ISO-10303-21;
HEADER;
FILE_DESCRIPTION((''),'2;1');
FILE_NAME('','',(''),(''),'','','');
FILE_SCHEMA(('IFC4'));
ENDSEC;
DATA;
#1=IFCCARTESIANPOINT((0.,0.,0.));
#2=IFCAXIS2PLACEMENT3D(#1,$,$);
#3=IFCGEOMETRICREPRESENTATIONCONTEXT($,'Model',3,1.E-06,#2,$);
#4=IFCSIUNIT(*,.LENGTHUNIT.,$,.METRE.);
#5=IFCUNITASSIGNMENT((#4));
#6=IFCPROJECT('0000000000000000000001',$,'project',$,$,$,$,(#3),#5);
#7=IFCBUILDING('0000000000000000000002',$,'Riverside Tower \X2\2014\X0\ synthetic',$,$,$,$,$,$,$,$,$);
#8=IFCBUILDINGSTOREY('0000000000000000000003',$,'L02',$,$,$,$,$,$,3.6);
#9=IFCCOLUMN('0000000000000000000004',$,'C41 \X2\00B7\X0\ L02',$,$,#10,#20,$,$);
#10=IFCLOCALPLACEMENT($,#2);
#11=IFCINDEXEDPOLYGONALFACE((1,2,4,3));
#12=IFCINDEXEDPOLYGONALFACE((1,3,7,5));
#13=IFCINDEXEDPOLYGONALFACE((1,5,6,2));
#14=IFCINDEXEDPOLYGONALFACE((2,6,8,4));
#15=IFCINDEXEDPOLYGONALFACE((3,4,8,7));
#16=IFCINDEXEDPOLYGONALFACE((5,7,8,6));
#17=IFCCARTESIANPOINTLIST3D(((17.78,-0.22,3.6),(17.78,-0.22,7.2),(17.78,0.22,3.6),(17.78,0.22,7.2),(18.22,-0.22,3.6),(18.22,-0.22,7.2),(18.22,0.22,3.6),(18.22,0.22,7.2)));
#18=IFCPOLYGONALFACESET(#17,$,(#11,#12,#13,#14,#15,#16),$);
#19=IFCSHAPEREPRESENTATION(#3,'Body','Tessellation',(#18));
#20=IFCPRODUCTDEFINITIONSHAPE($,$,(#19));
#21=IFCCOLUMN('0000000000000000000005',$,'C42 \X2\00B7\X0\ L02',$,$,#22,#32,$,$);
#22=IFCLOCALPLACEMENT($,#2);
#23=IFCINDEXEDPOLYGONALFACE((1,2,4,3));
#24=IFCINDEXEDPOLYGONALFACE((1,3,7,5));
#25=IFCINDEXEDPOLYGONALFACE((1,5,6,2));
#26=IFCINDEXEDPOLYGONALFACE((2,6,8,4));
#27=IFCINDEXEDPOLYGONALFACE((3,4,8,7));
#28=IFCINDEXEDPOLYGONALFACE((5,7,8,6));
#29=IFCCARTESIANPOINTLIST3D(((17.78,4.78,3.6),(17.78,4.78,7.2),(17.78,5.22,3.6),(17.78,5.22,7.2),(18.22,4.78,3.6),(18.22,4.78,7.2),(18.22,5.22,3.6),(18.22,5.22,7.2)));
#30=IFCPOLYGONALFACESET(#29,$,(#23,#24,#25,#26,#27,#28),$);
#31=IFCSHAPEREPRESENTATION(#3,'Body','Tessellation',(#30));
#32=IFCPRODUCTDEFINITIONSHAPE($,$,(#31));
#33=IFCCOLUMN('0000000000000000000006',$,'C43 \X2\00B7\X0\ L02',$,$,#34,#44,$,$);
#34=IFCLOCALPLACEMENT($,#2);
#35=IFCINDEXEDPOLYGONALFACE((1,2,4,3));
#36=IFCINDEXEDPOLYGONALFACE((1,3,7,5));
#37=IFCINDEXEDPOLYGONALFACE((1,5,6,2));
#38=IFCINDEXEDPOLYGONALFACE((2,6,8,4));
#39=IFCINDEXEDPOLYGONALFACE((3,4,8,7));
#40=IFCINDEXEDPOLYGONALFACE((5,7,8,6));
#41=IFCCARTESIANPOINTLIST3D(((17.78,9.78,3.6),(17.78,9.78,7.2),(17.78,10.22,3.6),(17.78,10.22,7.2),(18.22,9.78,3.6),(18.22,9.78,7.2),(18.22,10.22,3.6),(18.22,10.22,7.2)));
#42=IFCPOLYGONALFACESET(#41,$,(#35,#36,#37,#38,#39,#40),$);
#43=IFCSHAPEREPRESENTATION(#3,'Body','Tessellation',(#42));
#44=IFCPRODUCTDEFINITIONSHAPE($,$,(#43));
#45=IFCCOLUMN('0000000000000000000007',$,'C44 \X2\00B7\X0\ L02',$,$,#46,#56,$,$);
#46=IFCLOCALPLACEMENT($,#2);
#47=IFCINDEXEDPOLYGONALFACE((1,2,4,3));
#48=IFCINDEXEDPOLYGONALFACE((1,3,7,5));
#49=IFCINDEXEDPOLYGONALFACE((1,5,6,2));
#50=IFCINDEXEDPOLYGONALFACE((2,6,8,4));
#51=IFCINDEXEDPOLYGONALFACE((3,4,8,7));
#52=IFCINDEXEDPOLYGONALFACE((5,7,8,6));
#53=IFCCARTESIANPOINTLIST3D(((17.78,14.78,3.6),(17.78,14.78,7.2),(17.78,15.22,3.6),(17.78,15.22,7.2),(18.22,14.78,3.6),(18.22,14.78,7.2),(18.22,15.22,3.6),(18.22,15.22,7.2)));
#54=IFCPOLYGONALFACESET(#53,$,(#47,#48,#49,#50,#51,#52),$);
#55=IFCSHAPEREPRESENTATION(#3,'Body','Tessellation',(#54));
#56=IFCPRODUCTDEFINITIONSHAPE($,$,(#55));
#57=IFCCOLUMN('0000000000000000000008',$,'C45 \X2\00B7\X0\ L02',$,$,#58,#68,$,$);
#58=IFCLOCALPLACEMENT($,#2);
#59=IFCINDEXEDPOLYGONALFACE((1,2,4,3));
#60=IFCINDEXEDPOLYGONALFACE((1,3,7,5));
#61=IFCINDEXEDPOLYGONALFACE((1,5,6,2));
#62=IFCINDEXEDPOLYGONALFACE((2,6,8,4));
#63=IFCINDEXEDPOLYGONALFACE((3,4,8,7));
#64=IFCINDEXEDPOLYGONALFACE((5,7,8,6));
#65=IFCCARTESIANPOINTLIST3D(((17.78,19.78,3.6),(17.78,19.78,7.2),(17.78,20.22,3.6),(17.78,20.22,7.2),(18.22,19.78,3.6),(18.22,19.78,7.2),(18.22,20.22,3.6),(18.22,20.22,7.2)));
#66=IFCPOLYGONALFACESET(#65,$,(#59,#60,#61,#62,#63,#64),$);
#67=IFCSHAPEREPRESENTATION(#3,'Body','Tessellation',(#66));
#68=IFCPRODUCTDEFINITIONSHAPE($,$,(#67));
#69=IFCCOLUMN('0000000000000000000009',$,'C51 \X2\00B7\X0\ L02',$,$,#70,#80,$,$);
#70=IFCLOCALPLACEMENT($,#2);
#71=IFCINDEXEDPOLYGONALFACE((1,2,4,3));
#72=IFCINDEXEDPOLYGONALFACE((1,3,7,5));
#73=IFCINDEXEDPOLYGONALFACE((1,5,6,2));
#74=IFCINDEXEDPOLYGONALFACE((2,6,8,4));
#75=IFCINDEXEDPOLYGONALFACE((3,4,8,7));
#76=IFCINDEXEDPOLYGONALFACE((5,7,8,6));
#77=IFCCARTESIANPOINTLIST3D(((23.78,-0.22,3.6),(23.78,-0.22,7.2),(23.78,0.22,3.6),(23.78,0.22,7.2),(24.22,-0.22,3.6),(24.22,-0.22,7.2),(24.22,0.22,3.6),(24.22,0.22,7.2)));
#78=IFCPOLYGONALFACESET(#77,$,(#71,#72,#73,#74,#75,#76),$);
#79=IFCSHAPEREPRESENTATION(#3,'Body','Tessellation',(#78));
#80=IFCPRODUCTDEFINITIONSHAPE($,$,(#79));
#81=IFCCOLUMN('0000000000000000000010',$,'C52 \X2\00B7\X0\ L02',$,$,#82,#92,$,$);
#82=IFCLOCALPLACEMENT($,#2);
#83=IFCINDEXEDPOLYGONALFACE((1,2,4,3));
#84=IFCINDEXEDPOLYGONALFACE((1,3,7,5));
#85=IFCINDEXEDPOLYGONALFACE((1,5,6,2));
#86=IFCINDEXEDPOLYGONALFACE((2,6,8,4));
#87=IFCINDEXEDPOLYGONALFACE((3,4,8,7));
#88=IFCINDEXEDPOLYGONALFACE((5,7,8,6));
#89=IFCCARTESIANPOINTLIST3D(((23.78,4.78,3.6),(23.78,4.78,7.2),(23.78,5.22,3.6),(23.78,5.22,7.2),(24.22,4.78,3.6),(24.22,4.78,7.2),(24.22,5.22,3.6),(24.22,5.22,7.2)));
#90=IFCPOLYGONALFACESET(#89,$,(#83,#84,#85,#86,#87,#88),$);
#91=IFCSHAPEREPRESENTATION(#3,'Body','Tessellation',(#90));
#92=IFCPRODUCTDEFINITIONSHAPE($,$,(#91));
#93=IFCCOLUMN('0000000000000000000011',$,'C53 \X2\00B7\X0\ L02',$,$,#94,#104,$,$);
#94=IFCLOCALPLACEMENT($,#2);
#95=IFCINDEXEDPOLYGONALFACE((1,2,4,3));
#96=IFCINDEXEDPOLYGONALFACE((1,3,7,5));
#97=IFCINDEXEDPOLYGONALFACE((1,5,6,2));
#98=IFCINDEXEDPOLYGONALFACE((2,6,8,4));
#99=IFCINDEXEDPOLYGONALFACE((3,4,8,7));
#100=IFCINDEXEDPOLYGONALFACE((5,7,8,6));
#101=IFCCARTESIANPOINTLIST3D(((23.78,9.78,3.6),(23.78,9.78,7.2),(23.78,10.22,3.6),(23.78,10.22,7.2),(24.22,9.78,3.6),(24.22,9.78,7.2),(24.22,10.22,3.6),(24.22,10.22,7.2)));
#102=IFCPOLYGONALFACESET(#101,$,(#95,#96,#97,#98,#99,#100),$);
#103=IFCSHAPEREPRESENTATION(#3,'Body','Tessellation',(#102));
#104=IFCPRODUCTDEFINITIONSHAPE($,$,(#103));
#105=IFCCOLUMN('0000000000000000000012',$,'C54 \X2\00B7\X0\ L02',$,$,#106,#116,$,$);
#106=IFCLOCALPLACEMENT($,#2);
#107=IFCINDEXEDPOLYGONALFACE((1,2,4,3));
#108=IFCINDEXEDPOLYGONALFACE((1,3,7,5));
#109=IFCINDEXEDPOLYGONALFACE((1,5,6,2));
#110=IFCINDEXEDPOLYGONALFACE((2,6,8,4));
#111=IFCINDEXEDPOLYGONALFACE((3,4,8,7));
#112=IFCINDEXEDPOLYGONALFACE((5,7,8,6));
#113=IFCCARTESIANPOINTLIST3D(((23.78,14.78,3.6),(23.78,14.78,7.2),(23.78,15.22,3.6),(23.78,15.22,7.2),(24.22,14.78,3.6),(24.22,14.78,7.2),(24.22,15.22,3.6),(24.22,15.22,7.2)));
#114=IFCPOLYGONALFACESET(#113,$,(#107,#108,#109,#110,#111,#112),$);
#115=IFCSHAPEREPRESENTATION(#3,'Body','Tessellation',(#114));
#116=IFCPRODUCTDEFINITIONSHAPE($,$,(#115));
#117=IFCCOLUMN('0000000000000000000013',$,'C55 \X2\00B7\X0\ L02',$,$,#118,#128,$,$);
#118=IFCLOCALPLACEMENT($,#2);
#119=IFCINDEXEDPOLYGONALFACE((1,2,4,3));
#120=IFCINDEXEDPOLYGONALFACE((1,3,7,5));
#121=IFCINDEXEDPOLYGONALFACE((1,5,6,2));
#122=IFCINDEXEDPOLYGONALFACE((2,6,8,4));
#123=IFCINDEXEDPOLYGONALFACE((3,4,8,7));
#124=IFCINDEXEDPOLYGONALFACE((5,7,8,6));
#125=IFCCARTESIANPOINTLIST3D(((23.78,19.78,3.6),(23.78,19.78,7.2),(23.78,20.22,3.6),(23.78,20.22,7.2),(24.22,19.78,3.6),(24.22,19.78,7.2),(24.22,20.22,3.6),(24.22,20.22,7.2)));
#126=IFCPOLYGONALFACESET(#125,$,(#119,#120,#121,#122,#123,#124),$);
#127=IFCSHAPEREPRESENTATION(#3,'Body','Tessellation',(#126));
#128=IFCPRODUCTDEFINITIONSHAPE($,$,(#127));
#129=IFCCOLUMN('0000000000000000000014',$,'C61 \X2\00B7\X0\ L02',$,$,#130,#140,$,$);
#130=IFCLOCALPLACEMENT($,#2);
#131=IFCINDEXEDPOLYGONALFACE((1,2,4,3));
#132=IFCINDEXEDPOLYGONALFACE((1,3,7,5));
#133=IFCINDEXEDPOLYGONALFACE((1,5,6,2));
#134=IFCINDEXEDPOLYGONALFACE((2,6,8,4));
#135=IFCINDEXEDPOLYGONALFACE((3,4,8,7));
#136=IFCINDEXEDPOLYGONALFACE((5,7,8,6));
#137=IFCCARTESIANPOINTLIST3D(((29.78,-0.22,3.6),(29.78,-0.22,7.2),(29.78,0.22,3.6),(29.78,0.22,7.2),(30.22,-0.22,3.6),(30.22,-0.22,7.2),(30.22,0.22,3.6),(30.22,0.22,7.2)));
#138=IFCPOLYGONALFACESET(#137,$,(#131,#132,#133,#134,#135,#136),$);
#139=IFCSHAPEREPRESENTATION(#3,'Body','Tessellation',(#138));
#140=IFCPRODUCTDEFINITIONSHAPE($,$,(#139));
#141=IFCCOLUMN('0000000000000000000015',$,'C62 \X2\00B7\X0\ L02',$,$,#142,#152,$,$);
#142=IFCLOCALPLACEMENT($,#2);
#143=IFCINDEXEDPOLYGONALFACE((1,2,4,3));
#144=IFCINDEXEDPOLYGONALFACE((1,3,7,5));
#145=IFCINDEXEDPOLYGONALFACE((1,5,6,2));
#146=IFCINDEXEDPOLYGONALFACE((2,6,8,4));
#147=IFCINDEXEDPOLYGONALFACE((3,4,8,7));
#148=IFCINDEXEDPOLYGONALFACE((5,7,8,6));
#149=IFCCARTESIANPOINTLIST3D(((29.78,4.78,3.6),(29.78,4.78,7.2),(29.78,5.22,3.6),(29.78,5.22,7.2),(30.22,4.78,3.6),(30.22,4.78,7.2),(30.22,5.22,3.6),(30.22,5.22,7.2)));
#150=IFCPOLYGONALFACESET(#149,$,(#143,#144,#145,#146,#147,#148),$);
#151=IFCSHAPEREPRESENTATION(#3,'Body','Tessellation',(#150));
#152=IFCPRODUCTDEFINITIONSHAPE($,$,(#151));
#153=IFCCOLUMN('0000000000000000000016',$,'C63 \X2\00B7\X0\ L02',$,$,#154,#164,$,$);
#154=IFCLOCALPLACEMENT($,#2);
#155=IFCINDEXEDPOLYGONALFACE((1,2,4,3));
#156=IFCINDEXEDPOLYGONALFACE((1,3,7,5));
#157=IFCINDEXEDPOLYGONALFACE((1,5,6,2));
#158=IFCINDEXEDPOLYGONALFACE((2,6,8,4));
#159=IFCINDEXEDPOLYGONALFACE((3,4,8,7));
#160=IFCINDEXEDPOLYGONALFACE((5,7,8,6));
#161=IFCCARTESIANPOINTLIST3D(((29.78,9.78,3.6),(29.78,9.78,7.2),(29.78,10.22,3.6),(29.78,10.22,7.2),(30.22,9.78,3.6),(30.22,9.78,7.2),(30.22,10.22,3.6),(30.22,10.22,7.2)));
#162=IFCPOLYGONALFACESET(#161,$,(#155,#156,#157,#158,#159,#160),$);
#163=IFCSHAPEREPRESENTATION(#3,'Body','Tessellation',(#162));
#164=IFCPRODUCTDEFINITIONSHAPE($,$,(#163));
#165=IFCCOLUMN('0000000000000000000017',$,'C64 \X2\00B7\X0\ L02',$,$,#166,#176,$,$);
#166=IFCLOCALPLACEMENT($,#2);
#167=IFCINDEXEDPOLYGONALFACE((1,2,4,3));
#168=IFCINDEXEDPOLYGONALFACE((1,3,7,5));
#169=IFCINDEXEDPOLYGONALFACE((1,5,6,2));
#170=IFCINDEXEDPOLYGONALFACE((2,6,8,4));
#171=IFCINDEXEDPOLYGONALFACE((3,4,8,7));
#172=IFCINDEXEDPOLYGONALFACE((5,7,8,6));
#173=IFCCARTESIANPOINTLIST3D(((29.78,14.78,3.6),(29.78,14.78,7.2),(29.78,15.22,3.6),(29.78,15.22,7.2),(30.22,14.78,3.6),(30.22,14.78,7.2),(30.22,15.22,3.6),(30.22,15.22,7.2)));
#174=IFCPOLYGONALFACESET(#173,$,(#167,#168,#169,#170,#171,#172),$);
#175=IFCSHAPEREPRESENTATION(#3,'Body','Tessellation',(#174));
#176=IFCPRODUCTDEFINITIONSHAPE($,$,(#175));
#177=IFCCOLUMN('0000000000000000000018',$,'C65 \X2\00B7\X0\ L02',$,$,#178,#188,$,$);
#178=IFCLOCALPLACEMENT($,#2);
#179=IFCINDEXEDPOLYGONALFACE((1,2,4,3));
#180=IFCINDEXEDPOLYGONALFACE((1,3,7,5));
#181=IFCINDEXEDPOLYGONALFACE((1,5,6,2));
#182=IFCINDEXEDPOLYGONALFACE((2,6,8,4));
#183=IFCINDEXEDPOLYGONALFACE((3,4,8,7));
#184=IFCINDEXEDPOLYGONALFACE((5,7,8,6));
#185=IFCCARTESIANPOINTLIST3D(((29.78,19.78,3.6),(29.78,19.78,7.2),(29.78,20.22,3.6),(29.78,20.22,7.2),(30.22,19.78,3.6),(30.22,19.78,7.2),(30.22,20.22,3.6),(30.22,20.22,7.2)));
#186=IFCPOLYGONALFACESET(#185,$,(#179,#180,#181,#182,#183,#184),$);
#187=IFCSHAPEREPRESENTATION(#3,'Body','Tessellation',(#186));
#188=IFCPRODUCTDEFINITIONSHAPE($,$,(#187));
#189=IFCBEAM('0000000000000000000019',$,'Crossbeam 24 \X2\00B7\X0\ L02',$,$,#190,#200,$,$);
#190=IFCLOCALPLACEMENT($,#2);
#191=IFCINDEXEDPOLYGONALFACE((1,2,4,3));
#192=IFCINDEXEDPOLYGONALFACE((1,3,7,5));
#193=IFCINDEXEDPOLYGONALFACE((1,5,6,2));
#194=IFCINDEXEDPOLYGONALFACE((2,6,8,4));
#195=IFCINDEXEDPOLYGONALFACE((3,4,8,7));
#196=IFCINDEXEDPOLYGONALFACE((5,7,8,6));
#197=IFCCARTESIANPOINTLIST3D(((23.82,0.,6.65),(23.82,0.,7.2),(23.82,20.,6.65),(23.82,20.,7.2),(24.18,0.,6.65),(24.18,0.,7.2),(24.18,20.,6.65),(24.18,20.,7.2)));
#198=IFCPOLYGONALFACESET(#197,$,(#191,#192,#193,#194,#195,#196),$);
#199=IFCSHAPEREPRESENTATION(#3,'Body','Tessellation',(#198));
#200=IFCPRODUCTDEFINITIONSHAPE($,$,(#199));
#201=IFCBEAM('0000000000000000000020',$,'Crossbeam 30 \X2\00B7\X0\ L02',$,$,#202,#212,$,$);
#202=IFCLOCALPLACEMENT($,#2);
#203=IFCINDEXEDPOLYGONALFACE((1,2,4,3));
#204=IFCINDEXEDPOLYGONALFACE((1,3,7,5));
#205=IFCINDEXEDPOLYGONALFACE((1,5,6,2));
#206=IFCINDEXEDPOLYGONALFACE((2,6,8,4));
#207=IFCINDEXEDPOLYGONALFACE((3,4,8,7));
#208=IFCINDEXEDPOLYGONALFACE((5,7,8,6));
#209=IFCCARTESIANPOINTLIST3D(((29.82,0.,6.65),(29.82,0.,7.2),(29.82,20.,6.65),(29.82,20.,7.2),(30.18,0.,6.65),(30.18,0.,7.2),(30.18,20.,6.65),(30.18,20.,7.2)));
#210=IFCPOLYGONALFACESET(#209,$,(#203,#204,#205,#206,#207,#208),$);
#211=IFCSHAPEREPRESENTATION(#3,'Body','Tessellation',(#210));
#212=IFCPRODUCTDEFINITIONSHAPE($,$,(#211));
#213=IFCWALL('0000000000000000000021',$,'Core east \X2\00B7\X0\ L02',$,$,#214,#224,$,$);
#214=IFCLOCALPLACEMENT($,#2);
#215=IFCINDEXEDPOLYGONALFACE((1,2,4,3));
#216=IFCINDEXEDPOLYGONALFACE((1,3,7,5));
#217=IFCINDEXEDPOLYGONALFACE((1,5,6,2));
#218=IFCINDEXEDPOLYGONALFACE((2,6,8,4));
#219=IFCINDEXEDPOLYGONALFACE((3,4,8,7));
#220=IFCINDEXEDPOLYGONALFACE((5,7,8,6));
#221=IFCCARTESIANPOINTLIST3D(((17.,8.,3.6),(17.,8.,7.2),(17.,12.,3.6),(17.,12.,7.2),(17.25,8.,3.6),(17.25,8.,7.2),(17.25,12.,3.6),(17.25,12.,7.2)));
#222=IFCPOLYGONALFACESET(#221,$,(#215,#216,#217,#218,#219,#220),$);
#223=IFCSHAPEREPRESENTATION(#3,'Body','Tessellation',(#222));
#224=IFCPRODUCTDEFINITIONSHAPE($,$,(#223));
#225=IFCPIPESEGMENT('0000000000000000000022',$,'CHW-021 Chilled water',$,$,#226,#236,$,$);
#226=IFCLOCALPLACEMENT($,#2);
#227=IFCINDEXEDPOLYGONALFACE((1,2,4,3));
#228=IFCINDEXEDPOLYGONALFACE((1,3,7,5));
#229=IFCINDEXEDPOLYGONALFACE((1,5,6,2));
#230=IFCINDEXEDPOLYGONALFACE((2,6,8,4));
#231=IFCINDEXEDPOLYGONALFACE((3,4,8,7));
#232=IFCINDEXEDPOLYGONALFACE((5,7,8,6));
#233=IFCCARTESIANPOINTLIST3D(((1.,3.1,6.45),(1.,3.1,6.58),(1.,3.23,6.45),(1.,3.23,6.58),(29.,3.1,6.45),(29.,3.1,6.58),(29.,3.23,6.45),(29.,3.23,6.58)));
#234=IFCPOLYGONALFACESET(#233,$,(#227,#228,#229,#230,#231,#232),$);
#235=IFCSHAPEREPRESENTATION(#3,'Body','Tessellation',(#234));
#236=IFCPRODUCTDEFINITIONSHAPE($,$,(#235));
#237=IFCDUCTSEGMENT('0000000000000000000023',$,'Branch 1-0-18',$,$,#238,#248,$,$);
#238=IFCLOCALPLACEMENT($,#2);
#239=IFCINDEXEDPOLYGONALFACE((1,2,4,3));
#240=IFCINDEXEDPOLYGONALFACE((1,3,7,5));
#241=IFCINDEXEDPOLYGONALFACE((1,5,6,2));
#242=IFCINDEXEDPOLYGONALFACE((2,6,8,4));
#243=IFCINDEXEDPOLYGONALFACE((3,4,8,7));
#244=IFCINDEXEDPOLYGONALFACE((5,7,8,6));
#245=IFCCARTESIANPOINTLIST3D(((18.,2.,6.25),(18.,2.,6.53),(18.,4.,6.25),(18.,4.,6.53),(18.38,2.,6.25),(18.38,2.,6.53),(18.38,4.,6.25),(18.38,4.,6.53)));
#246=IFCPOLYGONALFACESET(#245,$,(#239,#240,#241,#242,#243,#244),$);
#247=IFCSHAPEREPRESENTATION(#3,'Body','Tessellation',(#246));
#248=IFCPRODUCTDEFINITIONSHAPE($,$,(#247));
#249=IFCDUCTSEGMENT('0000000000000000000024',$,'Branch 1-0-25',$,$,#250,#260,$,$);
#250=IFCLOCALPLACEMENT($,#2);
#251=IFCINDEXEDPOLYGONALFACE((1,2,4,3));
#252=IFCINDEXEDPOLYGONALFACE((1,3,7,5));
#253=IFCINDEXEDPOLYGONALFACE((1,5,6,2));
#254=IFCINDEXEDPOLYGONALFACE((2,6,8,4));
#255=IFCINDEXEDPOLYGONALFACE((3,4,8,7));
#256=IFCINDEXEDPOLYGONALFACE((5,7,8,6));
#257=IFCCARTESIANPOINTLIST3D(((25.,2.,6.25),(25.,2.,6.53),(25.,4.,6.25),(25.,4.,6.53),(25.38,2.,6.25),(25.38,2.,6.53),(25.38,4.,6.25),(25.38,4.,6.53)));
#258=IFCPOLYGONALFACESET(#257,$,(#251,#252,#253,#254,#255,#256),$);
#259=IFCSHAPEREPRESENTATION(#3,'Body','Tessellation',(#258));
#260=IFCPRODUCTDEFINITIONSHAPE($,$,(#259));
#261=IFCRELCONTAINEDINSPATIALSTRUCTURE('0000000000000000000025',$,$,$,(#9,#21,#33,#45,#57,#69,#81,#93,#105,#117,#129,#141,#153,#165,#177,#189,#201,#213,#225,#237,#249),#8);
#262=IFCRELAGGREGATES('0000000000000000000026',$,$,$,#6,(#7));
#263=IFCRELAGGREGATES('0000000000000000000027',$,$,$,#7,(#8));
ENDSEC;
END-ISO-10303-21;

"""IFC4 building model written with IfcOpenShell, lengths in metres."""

from ifc_helpers import new_model, si_unit, frame, origin, place, context, project, spatial, rectangle, extrude, element, save


model = new_model("IFC4")

# Units and contexts
model_context = context("Model", 3, precision=1e-06, world=origin())
ifc_project = project(units=[si_unit("LENGTHUNIT", "METRE")], contexts=[model_context])

# Building, storey
building = spatial("IfcBuilding", under=ifc_project, Name="Riverside Tower — synthetic")
storey = spatial("IfcBuildingStorey", under=building, Name="L02", Elevation=3.6)

# Columns
for number, where, name in (
    (1, (18.0, 0.0, 3.6), "C41 · L02"),
    (2, (18.0, 5.0, 3.6), "C42 · L02"),
    (3, (18.0, 10.0, 3.6), "C43 · L02"),
    (4, (18.0, 15.0, 3.6), "C44 · L02"),
    (5, (18.0, 20.0, 3.6), "C45 · L02"),
    (6, (24.0, 0.0, 3.6), "C51 · L02"),
    (7, (24.0, 5.0, 3.6), "C52 · L02"),
    (8, (24.0, 10.0, 3.6), "C53 · L02"),
    (9, (24.0, 15.0, 3.6), "C54 · L02"),
    (10, (24.0, 20.0, 3.6), "C55 · L02"),
    (11, (30.0, 0.0, 3.6), "C61 · L02"),
    (12, (30.0, 5.0, 3.6), "C62 · L02"),
    (13, (30.0, 10.0, 3.6), "C63 · L02"),
    (14, (30.0, 15.0, 3.6), "C64 · L02"),
    (15, (30.0, 20.0, 3.6), "C65 · L02"),
):
    element("IfcColumn", number, at=place(None, frame(where)), inside=storey, Name=name, context=model_context, shape_type="SweptSolid", body=[
        extrude(rectangle(XDim=0.44, YDim=0.44), origin(), (0.0, 0.0, 1.0), 3.6),
    ])

# Beams
for number, where, name in (
    (16, (24.0, 10.0, 6.65), "Crossbeam 24 · L02"),
    (17, (30.0, 10.0, 6.65), "Crossbeam 30 · L02"),
):
    element("IfcBeam", number, at=place(None, frame(where)), inside=storey, Name=name, context=model_context, shape_type="SweptSolid", body=[
        extrude(rectangle(XDim=0.36, YDim=20.0), origin(), (0.0, 0.0, 1.0), 0.55),
    ])

# Wall
wall_placement = place(None, frame((17.125, 10.0, 3.6)))
element("IfcWall", 18, at=wall_placement, inside=storey, Name="Core east · L02", context=model_context, shape_type="SweptSolid", body=[
    extrude(rectangle(XDim=0.25, YDim=4.0), origin(), (0.0, 0.0, 1.0), 3.6),
])

# Pipe segment
pipe_segment_1_placement = place(None, frame((15.0, 3.165, 6.45)))
element("IfcPipeSegment", 19, at=pipe_segment_1_placement, inside=storey, Name="CHW-021 Chilled water", context=model_context, shape_type="SweptSolid", body=[
    extrude(rectangle(XDim=28.0, YDim=0.13), origin(), (0.0, 0.0, 1.0), 0.13),
])

# Duct segments
for number, where, name in (
    (20, (18.19, 3.0, 6.25), "Branch 1-0-18"),
    (21, (25.19, 3.0, 6.25), "Branch 1-0-25"),
):
    element("IfcDuctSegment", number, at=place(None, frame(where)), inside=storey, Name=name, context=model_context, shape_type="SweptSolid", body=[
        extrude(rectangle(XDim=0.38, YDim=2.0), origin(), (0.0, 0.0, 1.0), 0.28),
    ])

save(model, "model.ifc")
